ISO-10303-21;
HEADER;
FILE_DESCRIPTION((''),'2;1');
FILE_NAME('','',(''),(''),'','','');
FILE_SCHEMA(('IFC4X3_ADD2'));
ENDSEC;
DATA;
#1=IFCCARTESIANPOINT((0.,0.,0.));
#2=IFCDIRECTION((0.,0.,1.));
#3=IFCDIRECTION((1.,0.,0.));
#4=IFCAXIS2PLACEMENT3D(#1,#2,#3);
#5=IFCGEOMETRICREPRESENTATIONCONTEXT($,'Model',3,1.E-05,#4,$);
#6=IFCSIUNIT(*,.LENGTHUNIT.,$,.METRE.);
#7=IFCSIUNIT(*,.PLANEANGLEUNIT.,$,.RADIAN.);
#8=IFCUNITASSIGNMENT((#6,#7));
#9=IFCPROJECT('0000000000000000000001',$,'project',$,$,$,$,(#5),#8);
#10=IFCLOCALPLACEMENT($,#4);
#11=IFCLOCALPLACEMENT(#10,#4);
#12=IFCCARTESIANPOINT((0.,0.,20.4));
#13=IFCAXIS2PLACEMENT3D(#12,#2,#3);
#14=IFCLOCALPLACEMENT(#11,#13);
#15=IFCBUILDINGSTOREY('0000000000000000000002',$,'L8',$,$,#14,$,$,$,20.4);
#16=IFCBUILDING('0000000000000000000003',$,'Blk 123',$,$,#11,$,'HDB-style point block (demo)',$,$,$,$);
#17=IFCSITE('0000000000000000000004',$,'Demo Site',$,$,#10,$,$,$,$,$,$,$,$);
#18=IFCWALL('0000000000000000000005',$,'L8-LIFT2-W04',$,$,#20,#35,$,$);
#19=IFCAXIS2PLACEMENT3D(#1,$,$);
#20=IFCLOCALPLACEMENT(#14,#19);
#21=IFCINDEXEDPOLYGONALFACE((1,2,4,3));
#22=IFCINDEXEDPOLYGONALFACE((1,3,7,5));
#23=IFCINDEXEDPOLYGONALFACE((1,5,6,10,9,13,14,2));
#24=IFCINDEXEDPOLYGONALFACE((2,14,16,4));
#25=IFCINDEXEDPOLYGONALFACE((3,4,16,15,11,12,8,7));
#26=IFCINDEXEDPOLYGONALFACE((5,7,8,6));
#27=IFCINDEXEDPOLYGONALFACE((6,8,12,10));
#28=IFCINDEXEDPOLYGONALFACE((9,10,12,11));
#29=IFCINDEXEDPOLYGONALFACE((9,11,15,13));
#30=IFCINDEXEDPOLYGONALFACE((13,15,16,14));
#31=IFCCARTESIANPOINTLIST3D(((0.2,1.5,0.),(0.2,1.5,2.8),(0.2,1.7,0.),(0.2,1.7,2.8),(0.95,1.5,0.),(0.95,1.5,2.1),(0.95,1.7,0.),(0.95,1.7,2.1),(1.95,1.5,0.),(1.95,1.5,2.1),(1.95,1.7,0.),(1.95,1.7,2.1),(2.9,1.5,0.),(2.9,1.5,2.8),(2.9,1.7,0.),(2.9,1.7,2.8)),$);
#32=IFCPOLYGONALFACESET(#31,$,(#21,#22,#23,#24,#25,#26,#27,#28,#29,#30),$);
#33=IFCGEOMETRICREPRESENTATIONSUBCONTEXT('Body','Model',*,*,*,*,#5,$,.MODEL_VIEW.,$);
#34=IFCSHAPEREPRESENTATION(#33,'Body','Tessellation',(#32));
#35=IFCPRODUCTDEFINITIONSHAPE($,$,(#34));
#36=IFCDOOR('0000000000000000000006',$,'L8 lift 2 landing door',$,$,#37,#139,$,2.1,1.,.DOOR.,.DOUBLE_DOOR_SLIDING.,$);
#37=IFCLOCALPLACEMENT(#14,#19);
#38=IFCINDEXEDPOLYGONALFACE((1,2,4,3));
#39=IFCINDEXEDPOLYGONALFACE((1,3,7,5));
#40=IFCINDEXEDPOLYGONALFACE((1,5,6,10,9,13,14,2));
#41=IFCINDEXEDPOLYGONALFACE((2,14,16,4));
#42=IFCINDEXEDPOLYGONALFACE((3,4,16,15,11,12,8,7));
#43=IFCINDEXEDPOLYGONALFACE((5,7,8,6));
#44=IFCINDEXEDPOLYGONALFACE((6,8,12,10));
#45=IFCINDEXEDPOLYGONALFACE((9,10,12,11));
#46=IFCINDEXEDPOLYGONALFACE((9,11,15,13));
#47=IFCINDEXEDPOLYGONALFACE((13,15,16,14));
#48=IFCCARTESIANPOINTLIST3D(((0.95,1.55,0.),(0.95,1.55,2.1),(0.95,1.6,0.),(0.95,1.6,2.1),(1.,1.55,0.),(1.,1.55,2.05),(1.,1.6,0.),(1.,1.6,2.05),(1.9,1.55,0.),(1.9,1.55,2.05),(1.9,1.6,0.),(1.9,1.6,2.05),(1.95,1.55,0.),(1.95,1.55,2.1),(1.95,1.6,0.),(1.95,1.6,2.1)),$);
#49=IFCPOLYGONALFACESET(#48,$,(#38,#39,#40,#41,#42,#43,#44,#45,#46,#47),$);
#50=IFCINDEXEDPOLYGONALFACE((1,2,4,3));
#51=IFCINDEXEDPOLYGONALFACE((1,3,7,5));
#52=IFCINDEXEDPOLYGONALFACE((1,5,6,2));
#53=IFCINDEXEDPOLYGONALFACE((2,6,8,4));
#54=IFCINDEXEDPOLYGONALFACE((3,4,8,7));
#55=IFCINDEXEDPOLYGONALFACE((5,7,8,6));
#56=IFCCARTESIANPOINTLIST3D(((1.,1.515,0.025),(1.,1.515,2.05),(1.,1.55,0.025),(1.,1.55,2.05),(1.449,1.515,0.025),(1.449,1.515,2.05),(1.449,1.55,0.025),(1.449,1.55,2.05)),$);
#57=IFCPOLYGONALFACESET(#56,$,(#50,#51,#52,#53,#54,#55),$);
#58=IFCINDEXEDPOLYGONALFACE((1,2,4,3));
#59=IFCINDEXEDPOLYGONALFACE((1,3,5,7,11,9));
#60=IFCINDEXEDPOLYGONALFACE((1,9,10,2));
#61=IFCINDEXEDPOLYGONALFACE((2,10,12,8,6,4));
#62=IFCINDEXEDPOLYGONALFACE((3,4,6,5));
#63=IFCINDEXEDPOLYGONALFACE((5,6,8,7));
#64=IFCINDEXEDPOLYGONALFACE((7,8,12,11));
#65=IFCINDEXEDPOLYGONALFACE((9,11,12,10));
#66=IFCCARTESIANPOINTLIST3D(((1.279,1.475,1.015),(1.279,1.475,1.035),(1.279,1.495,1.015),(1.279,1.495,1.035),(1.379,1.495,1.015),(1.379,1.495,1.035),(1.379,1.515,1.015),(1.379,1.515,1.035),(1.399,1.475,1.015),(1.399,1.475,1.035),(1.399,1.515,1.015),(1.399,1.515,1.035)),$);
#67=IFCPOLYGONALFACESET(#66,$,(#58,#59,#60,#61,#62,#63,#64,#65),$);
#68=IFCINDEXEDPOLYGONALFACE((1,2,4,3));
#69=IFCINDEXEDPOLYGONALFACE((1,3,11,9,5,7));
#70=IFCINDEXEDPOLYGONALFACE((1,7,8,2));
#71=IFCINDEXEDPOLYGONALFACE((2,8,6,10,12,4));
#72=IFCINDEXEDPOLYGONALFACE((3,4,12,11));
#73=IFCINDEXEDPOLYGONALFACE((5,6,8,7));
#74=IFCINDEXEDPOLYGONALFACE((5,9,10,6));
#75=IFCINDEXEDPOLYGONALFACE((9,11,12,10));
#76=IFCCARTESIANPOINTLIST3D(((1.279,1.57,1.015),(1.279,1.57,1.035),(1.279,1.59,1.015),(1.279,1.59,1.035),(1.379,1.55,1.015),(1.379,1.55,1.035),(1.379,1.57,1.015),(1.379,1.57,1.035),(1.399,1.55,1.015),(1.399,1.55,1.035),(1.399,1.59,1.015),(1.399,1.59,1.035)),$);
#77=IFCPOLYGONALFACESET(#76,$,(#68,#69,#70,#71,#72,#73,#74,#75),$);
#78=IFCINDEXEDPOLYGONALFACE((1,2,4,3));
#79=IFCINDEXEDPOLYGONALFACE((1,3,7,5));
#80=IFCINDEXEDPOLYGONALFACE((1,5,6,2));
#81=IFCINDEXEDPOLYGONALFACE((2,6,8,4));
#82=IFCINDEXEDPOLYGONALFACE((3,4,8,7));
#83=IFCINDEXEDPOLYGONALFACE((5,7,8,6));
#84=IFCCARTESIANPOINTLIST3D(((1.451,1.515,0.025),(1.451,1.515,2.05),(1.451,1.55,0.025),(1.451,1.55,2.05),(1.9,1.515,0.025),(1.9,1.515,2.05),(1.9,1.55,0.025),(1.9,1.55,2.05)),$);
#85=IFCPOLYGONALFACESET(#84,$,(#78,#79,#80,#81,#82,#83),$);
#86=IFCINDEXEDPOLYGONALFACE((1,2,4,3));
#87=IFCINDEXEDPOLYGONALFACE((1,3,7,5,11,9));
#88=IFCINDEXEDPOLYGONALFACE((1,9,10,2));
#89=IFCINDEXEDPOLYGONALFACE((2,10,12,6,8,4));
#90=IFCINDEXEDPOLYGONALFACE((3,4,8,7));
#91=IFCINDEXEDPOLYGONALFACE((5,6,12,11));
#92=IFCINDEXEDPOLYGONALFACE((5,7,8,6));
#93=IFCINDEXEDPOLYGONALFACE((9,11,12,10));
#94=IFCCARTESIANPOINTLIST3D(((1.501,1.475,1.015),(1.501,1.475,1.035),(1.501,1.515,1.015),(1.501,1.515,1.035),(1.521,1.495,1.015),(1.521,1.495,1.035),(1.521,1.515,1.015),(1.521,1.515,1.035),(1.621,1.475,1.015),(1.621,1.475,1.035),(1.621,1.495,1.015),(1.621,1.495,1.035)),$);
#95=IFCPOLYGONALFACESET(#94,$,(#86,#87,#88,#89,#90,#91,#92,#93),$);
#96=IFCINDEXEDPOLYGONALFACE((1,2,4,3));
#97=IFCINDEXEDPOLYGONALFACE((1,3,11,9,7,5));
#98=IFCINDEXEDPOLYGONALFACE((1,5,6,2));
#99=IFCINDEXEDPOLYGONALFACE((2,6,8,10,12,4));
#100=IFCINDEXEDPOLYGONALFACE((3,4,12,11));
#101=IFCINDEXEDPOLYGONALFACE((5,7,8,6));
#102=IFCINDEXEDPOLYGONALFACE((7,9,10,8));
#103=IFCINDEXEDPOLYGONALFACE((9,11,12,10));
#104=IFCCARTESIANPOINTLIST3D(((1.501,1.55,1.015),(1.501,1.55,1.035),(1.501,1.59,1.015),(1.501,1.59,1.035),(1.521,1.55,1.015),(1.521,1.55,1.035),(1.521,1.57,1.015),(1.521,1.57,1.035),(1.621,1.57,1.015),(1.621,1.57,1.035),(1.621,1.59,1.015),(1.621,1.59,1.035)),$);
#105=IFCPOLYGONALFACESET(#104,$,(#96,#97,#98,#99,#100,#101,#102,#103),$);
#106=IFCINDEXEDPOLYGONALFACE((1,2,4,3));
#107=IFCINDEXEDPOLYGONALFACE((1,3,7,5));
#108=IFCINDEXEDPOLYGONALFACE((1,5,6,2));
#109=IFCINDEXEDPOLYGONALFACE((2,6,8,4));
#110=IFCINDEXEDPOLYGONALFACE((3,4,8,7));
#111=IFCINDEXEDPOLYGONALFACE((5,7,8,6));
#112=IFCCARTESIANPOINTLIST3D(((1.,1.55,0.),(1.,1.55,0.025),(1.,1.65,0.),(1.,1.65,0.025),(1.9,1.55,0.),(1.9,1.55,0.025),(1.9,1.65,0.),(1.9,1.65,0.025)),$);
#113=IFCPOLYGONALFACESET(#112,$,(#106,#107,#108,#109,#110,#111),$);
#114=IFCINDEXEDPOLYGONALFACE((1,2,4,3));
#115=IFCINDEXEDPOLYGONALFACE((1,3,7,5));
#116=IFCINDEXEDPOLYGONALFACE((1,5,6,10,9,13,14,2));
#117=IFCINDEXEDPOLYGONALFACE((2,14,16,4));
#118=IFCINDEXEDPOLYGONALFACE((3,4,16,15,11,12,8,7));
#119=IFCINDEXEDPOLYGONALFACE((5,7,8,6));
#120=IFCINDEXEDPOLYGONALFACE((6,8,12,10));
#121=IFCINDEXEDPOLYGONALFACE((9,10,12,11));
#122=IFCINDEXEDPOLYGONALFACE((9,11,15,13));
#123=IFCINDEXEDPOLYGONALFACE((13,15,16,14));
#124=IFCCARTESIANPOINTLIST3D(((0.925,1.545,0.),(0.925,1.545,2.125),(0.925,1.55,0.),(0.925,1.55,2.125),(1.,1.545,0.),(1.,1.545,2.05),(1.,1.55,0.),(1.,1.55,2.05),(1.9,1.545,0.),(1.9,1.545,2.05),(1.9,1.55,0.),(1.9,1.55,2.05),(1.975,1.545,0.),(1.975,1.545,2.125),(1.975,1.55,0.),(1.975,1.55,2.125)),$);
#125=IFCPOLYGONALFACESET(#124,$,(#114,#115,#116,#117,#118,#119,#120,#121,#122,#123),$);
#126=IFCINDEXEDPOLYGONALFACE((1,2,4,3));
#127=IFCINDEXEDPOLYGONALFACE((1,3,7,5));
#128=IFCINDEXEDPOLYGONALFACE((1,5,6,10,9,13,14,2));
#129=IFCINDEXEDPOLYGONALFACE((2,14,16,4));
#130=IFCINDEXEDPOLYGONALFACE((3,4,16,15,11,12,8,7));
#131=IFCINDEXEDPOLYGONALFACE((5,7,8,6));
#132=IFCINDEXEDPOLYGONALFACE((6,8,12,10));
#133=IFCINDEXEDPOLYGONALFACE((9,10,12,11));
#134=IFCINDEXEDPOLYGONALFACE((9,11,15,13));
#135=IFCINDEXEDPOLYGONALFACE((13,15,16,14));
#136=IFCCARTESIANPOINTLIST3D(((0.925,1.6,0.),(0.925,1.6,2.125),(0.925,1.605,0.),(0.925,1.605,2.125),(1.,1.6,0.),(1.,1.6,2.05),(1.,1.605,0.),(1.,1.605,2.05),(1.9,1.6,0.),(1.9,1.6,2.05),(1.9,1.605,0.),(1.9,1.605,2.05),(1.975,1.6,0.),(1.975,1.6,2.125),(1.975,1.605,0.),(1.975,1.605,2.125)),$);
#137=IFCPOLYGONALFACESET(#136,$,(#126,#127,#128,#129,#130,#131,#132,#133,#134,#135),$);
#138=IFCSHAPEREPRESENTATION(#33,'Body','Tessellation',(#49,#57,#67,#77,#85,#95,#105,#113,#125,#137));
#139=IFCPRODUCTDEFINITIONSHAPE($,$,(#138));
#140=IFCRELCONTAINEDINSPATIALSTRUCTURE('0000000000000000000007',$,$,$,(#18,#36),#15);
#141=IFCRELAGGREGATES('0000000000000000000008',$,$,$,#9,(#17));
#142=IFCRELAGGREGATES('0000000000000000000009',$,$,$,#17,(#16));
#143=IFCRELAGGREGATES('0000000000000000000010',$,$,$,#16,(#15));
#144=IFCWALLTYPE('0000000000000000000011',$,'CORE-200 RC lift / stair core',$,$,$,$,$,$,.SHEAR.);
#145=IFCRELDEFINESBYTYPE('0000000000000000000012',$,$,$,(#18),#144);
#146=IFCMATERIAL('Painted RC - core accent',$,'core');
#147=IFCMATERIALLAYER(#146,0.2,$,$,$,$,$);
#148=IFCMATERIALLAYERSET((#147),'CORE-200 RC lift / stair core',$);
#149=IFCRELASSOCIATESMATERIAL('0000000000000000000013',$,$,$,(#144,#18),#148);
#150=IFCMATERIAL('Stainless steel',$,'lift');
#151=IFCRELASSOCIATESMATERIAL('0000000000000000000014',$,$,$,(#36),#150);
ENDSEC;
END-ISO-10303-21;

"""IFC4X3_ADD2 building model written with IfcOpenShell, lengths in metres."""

from ifc_helpers import new_model, si_unit, frame, origin_with_axes, place, context, subcontext, project, spatial, line, indexed_curve, outline, extrude, material, layer, layer_set, layer_usage, type_object, element, fill, save


model = new_model("IFC4X3_ADD2")

# Units and contexts
model_context = context("Model", 3, precision=1e-05, world=origin_with_axes())
body_context = subcontext(model_context, "Body", "Model", "MODEL_VIEW")
ifc_project = project(units=[si_unit("LENGTHUNIT", "METRE"), si_unit("PLANEANGLEUNIT", "RADIAN")], contexts=[model_context])

# Site, building, storey
site_placement = place(None, origin_with_axes())
site = spatial("IfcSite", under=ifc_project, at=site_placement, Name="Demo Site")
building_placement = place(site_placement, origin_with_axes())
building = spatial("IfcBuilding", under=site, at=building_placement, Name="Blk 123", LongName="HDB-style point block (demo)")
storey_placement = place(building_placement, frame((0.0, 0.0, 20.4), z_axis=(0.0, 0.0, 1.0), x_axis=(1.0, 0.0, 0.0)))
storey = spatial("IfcBuildingStorey", under=building, at=storey_placement, Name="L8", Elevation=20.4)

# Shared definitions
ifc_material_1 = material(Name="Painted RC - core accent", Category="core")
ifc_layer_1 = layer(ifc_material_1, 0.2)
ifc_layer_set_1 = layer_set([ifc_layer_1], Name="CORE-200 RC lift / stair core")
ifc_layer_usage_1 = layer_usage(ifc_layer_set_1, "AXIS2", "POSITIVE", 0.0)
wall_type_1 = type_object("IfcWallType", Name="CORE-200 RC lift / stair core", PredefinedType="SHEAR", material=ifc_layer_set_1)

# Wall, opening, door
wall_1_placement = place(storey_placement, frame((0.2, 1.5, 0.0), z_axis=(0.0, 0.0, 1.0), x_axis=(1.0, 0.0, 0.0)))
wall_1 = element("IfcWall", 1, at=wall_1_placement, inside=storey, type_object=wall_type_1, material=ifc_layer_usage_1, Name="L8-LIFT2-W04", context=body_context, shape_type="SweptSolid", body=[
    extrude(outline(indexed_curve([(0.0, 0.0), (0.0, 0.2), (2.7, 0.2), (2.7, 0.0), (0.0, 0.0)], self_intersect=False)), origin_with_axes(), (0.0, 0.0, 1.0), 2.8),
])
opening_1_placement = place(wall_1_placement, frame((0.75, -0.1, 0.0), z_axis=(0.0, 0.0, 1.0), x_axis=(1.0, 0.0, 0.0)))
opening_1 = element("IfcOpeningElement", 2, at=opening_1_placement, cuts=wall_1, context=body_context, shape_type="SweptSolid", body=[
    extrude(outline(indexed_curve([(0.0, 0.0), (0.0, 0.4), (1.0, 0.4), (1.0, 0.0), (0.0, 0.0)], self_intersect=False)), origin_with_axes(), (0.0, 0.0, 1.0), 2.1),
])
ifc_material_2 = material(Name="Stainless steel", Category="lift")
door_1_placement = place(opening_1_placement, frame((0.0, 0.15, 0.0), z_axis=(0.0, 0.0, 1.0), x_axis=(1.0, 0.0, 0.0)))
door_1 = element("IfcDoor", 3, at=door_1_placement, inside=storey, material=ifc_material_2, Name="L8 lift 2 landing door", OperationType="DOUBLE_DOOR_SLIDING", OverallHeight=2.1, OverallWidth=1.0, PredefinedType="DOOR", context=body_context, shape_type="SweptSolid", body=[
    extrude(outline(indexed_curve([(0.0, 0.0), (0.0, 2.1), (1.0, 2.1), (1.0, 0.0), (0.95, 0.0), (0.95, 2.05), (0.05, 2.05), (0.05, 0.0)], segments=[line(1, 2, 3, 4, 5, 6, 7, 8, 1)])), frame((0.0, 0.0, 0.0), z_axis=(0.0, -1.0, 0.0), x_axis=(1.0, 0.0, 0.0)), (0.0, 0.0, -1.0), 0.05),
    extrude(outline(indexed_curve([(0.0, 0.0), (0.449, 0.0), (0.449, 0.035), (0.0, 0.035)], segments=[line(1, 2, 3, 4, 1)])), frame((0.05, -0.035, 0.025), z_axis=(0.0, 0.0, 1.0), x_axis=(1.0, 0.0, 0.0)), (0.0, 0.0, 1.0), 2.025),
    extrude(outline(indexed_curve([(0.0, 0.0), (0.0, -0.04), (-0.12, -0.04), (-0.12, -0.02), (-0.02, -0.02), (-0.02, 0.0)], segments=[line(1, 2, 3, 4, 5, 6, 1)])), frame((0.449, -0.035, 1.015), z_axis=(0.0, 0.0, 1.0), x_axis=(1.0, 0.0, 0.0)), (0.0, 0.0, 1.0), 0.02),
    extrude(outline(indexed_curve([(0.0, 0.0), (0.0, 0.04), (-0.12, 0.04), (-0.12, 0.02), (-0.02, 0.02), (-0.02, 0.0)], segments=[line(1, 2, 3, 4, 5, 6, 1)])), frame((0.449, 0.0, 1.015), z_axis=(0.0, 0.0, 1.0), x_axis=(1.0, 0.0, 0.0)), (0.0, 0.0, 1.0), 0.02),
    extrude(outline(indexed_curve([(0.0, 0.0), (-0.449, 0.0), (-0.449, 0.035), (0.0, 0.035)], segments=[line(1, 2, 3, 4, 1)])), frame((0.95, -0.035, 0.025), z_axis=(0.0, 0.0, 1.0), x_axis=(1.0, 0.0, 0.0)), (0.0, 0.0, 1.0), 2.025),
    extrude(outline(indexed_curve([(0.0, 0.0), (0.0, -0.04), (0.12, -0.04), (0.12, -0.02), (0.02, -0.02), (0.02, 0.0)], segments=[line(1, 2, 3, 4, 5, 6, 1)])), frame((0.551, -0.035, 1.015), z_axis=(0.0, 0.0, 1.0), x_axis=(1.0, 0.0, 0.0)), (0.0, 0.0, 1.0), 0.02),
    extrude(outline(indexed_curve([(0.0, 0.0), (0.0, 0.04), (0.12, 0.04), (0.12, 0.02), (0.02, 0.02), (0.02, 0.0)], segments=[line(1, 2, 3, 4, 5, 6, 1)])), frame((0.551, 0.0, 1.015), z_axis=(0.0, 0.0, 1.0), x_axis=(1.0, 0.0, 0.0)), (0.0, 0.0, 1.0), 0.02),
    extrude(outline(indexed_curve([(0.0, 0.0), (0.9, 0.0), (0.9, 0.1), (0.0, 0.1)], segments=[line(1, 2, 3, 4, 1)])), frame((0.05, 0.0, 0.0), z_axis=(0.0, 0.0, 1.0), x_axis=(1.0, 0.0, 0.0)), (0.0, 0.0, 1.0), 0.025),
    extrude(outline(indexed_curve([(0.0, 0.0), (0.0, 2.125), (1.05, 2.125), (1.05, 0.0), (0.975, 0.0), (0.975, 2.05), (0.075, 2.05), (0.075, 0.0)], segments=[line(1, 2, 3, 4, 5, 6, 7, 8, 1)])), frame((-0.025, -0.005, 0.0), z_axis=(0.0, -1.0, 0.0), x_axis=(1.0, 0.0, 0.0)), (0.0, 0.0, -1.0), 0.005),
    extrude(outline(indexed_curve([(0.0, 0.0), (0.0, 2.125), (1.05, 2.125), (1.05, 0.0), (0.975, 0.0), (0.975, 2.05), (0.075, 2.05), (0.075, 0.0)], segments=[line(1, 2, 3, 4, 5, 6, 7, 8, 1)])), frame((-0.025, 0.05, 0.0), z_axis=(0.0, -1.0, 0.0), x_axis=(1.0, 0.0, 0.0)), (0.0, 0.0, -1.0), 0.005),
])
fill(opening_1, door_1)

save(model, "model.ifc")
